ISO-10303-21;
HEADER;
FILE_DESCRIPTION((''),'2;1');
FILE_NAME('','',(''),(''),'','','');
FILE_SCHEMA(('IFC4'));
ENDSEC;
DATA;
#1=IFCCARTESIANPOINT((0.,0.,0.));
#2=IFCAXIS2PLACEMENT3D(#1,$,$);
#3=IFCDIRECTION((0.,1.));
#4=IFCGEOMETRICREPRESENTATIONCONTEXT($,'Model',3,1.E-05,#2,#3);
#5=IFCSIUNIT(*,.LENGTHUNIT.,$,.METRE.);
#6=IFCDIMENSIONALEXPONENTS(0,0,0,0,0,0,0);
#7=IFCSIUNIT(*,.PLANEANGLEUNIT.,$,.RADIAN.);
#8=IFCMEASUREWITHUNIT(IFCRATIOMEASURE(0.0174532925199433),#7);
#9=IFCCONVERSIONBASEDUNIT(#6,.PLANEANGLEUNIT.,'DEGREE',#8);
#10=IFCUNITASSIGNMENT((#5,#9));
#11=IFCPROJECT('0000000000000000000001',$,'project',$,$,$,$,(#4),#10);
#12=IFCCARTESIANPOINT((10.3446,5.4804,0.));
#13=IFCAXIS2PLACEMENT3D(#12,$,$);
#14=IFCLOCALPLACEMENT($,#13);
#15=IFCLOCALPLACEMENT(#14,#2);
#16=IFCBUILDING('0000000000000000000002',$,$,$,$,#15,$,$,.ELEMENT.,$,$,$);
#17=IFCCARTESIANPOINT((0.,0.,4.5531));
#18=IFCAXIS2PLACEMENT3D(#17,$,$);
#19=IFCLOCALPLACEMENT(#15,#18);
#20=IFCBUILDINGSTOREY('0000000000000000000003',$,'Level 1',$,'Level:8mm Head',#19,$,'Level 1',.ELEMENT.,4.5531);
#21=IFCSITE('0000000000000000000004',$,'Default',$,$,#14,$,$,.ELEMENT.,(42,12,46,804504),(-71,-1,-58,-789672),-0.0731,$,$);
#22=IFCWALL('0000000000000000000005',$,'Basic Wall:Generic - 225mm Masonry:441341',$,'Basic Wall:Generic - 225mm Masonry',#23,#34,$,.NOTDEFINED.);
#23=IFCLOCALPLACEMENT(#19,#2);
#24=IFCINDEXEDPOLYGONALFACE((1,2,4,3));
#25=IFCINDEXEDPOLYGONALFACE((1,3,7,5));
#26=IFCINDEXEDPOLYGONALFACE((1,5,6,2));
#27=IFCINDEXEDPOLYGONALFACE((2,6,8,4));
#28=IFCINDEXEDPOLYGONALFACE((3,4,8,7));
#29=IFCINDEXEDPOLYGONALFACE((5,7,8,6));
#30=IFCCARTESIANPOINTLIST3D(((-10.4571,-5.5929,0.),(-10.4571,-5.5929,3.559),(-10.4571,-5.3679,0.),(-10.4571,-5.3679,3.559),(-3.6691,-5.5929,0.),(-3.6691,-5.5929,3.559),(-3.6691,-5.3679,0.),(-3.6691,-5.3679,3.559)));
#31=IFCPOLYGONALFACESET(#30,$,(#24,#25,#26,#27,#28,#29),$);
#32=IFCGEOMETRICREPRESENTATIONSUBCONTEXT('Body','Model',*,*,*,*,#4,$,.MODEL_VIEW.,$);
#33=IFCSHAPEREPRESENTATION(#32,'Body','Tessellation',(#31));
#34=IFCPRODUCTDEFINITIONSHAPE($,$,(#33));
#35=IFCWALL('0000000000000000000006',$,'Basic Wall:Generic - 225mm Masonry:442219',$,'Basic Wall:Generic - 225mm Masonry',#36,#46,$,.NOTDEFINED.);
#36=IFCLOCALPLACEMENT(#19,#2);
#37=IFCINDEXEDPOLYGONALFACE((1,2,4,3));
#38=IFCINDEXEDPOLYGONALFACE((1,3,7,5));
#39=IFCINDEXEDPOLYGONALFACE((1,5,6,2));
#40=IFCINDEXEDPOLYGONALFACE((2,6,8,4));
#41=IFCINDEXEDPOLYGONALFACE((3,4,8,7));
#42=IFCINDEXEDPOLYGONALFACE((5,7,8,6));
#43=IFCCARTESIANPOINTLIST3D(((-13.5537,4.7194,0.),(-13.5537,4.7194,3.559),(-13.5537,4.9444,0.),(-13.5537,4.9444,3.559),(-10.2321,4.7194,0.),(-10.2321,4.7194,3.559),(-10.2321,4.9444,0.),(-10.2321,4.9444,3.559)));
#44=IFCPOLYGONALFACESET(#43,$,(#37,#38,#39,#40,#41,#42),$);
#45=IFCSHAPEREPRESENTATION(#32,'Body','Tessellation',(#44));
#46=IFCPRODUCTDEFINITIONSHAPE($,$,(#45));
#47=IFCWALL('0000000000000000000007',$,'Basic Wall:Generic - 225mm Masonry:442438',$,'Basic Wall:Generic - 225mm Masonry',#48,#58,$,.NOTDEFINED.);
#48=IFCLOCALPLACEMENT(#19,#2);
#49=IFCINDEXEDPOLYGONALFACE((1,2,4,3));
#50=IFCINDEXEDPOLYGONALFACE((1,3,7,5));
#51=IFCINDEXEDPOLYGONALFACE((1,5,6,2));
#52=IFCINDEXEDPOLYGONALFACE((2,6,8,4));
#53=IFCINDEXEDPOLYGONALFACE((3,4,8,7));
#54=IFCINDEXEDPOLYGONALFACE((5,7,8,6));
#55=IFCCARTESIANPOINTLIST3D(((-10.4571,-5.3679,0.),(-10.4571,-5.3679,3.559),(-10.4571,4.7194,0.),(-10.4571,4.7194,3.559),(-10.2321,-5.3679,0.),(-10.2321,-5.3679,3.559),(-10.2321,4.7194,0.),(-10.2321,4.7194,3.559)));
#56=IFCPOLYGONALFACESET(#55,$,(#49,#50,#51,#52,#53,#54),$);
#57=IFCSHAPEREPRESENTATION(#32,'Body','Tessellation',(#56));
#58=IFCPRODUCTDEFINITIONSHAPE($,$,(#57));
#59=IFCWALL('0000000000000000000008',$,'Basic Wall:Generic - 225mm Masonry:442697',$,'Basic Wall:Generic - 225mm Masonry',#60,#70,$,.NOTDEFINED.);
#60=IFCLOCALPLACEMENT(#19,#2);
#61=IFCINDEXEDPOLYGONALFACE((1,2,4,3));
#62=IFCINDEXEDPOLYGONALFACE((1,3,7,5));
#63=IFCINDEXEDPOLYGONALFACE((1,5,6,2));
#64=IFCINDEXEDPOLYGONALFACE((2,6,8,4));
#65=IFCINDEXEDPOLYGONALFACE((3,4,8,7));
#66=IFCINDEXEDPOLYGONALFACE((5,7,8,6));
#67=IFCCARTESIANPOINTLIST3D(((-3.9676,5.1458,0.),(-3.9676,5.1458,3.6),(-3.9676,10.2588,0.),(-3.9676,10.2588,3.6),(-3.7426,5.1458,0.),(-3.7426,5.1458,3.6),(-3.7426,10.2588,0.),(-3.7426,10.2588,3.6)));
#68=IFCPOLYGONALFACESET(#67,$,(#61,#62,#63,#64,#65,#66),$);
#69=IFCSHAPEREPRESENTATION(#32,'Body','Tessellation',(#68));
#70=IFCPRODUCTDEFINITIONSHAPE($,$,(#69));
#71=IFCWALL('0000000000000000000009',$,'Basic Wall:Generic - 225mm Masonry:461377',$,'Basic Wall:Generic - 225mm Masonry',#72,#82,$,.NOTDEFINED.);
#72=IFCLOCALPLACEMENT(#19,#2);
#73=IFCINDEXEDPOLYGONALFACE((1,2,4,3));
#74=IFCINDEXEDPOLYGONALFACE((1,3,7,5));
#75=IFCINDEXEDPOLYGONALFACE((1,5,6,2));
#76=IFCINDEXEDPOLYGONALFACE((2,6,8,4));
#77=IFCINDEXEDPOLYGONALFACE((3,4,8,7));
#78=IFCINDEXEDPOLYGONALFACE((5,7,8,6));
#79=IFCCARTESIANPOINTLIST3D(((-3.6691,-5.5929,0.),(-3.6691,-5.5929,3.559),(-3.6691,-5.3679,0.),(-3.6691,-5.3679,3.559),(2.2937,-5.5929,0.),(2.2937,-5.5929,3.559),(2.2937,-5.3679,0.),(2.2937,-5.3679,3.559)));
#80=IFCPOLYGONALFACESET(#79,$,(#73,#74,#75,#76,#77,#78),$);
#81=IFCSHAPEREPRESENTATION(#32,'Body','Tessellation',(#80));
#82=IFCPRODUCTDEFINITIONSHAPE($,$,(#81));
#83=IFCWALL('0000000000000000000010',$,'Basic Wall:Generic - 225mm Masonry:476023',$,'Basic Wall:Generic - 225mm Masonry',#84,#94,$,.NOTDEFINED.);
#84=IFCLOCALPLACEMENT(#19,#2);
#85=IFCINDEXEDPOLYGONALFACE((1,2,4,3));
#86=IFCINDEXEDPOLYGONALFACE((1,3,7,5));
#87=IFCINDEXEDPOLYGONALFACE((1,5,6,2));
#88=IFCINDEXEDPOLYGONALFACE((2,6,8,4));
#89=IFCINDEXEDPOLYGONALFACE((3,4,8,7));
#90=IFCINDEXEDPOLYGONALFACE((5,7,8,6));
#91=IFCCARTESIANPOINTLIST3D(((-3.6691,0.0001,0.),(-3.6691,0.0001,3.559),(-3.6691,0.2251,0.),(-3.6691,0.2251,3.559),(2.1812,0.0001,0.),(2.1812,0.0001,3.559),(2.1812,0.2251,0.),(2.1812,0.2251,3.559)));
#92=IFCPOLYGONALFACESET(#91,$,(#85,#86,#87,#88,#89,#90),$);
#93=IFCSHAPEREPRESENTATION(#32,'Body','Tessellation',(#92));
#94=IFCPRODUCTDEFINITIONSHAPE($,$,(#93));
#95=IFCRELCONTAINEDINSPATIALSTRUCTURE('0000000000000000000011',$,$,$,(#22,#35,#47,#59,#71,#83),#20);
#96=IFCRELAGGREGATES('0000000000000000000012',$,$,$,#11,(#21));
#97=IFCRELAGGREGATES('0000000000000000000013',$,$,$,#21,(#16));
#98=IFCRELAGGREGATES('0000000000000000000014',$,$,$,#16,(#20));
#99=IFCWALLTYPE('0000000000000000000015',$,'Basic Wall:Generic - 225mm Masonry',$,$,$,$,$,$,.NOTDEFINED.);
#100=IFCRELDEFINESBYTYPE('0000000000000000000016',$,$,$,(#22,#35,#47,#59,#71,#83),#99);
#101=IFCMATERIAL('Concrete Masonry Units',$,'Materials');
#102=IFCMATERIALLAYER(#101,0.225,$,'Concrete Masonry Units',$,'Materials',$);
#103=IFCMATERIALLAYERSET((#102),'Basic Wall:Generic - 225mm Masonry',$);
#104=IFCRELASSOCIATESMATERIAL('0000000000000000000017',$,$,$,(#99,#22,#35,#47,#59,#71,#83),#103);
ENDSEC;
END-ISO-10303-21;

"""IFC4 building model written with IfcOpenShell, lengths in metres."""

from ifc_helpers import new_model, entity, si_unit, converted_unit, direction, frame, frame_2d, origin, place, context, subcontext, project, spatial, polyline, rectangle, extrude, clip, bounded_halfspace, material, layer, layer_set, layer_usage, type_object, element, save


model = new_model("IFC4")

# Units and contexts
model_context = context("Model", 3, precision=1e-05, world=origin(), true_north=direction((0.0, 1.0)))
body_context = subcontext(model_context, "Body", "Model", "MODEL_VIEW")
ifc_project = project(units=[si_unit("LENGTHUNIT", "METRE"), converted_unit("PLANEANGLEUNIT", "DEGREE", entity("IfcRatioMeasure", 0.0174532925199433), si_unit("PLANEANGLEUNIT", "RADIAN"), dimensions=[0, 0, 0, 0, 0, 0, 0])], contexts=[model_context])

# Site, building, storey
site_placement = place(None, frame((10.3446, 5.4804, 0.0)))
site = spatial("IfcSite", under=ifc_project, at=site_placement, Name="Default", CompositionType="ELEMENT", RefLatitude=(42, 12, 46, 804504), RefLongitude=(-71, -1, -58, -789672), RefElevation=-0.0731)
building_placement = place(site_placement, origin())
building = spatial("IfcBuilding", under=site, at=building_placement, CompositionType="ELEMENT")
storey_placement = place(building_placement, frame((0.0, 0.0, 4.5531)))
storey = spatial("IfcBuildingStorey", under=building, at=storey_placement, Name="Level 1", ObjectType="Level:8mm Head", LongName="Level 1", CompositionType="ELEMENT", Elevation=4.5531)

# Walls
ifc_material_1 = material(Name="Concrete Masonry Units", Category="Materials")
ifc_layer = layer(ifc_material_1, 0.225, Name="Concrete Masonry Units", Category="Materials")
ifc_layer_set = layer_set([ifc_layer], Name="Basic Wall:Generic - 225mm Masonry")
ifc_layer_usage_1 = layer_usage(ifc_layer_set, "AXIS2", "NEGATIVE", 0.1125)
wall_type = type_object("IfcWallType", Name="Basic Wall:Generic - 225mm Masonry", PredefinedType="NOTDEFINED", material=ifc_layer_set)
wall_1_placement = place(storey_placement, frame((-10.4571, -5.4804, 0.0)))
element("IfcWall", 1, at=wall_1_placement, inside=storey, type_object=wall_type, material=ifc_layer_usage_1, Name="Basic Wall:Generic - 225mm Masonry:441341", ObjectType="Basic Wall:Generic - 225mm Masonry", PredefinedType="NOTDEFINED", context=body_context, shape_type="Clipping", body=[
    clip(extrude(rectangle(XDim=6.7881, YDim=0.225, at=frame_2d((3.394, 0.0), x_axis=(-1.0, 0.0))), origin(), (0.0, 0.0, 1.0), 3.559), bounded_halfspace(frame((6.7881, 0.0, 3.559), z_axis=(0.0, 0.0, -1.0), x_axis=(-1.0, 0.0, 0.0)), True, frame((6.7881, 0.0, 3.559)), polyline([(0.0, 0.0), (0.0, 0.1125), (-0.1125, 0.1125), (-6.5631, 0.1125), (-6.6756, 0.1125), (-6.6756, 0.0), (0.0, 0.0)]))),
])
ifc_layer_usage_2 = layer_usage(ifc_layer_set, "AXIS2", "NEGATIVE", 0.1125)
wall_2_placement = place(storey_placement, frame((-13.5537, 4.8319, 0.0)))
element("IfcWall", 2, at=wall_2_placement, inside=storey, type_object=wall_type, material=ifc_layer_usage_2, Name="Basic Wall:Generic - 225mm Masonry:442219", ObjectType="Basic Wall:Generic - 225mm Masonry", PredefinedType="NOTDEFINED", context=body_context, shape_type="Clipping", body=[
    clip(extrude(rectangle(XDim=3.3216, YDim=0.225, at=frame_2d((1.6608, 0.0), x_axis=(-1.0, 0.0))), origin(), (0.0, 0.0, 1.0), 3.559), bounded_halfspace(frame((3.2091, -0.1125, 3.559), z_axis=(0.0, 0.0, -1.0), x_axis=(-1.0, 0.0, 0.0)), True, frame((3.2091, -0.1125, 3.559)), polyline([(0.0, 0.0), (0.1125, 0.0), (0.1125, 0.2014), (0.1125, 0.225), (0.0, 0.225), (0.0, 0.0)]))),
])
ifc_layer_usage_3 = layer_usage(ifc_layer_set, "AXIS2", "NEGATIVE", 0.1125)
wall_3_placement = place(storey_placement, frame((-10.3446, 4.7194, 0.0), z_axis=(0.0, 0.0, 1.0), x_axis=(0.0, -1.0, 0.0)))
element("IfcWall", 3, at=wall_3_placement, inside=storey, type_object=wall_type, material=ifc_layer_usage_3, Name="Basic Wall:Generic - 225mm Masonry:442438", ObjectType="Basic Wall:Generic - 225mm Masonry", PredefinedType="NOTDEFINED", context=body_context, shape_type="Clipping", body=[
    clip(extrude(rectangle(XDim=10.0873, YDim=0.225, at=frame_2d((5.0437, 0.0), x_axis=(-1.0, 0.0))), origin(), (0.0, 0.0, 1.0), 3.559), bounded_halfspace(frame((10.0873, 0.0, 3.559), z_axis=(0.0, 0.0, -1.0), x_axis=(0.0, -1.0, 0.0)), True, frame((10.0873, 0.0, 3.559)), polyline([(0.0, 0.0), (0.0, 0.1125), (-10.0873, 0.1125), (-10.0873, 0.0), (0.0, 0.0)]))),
])
ifc_layer_usage_4 = layer_usage(ifc_layer_set, "AXIS2", "NEGATIVE", 0.1125)
wall_4_placement = place(storey_placement, frame((-3.8551, 10.2588, 0.0), z_axis=(0.0, 0.0, 1.0), x_axis=(0.0, -1.0, 0.0)))
element("IfcWall", 4, at=wall_4_placement, inside=storey, type_object=wall_type, material=ifc_layer_usage_4, Name="Basic Wall:Generic - 225mm Masonry:442697", ObjectType="Basic Wall:Generic - 225mm Masonry", PredefinedType="NOTDEFINED", context=body_context, shape_type="SweptSolid", body=[
    extrude(rectangle(XDim=5.113, YDim=0.225, at=frame_2d((2.5565, 0.0), x_axis=(-1.0, 0.0))), origin(), (0.0, 0.0, 1.0), 3.6),
])
ifc_layer_usage_5 = layer_usage(ifc_layer_set, "AXIS2", "NEGATIVE", 0.1125)
wall_5_placement = place(storey_placement, frame((-3.6691, -5.4804, 0.0)))
element("IfcWall", 5, at=wall_5_placement, inside=storey, type_object=wall_type, material=ifc_layer_usage_5, Name="Basic Wall:Generic - 225mm Masonry:461377", ObjectType="Basic Wall:Generic - 225mm Masonry", PredefinedType="NOTDEFINED", context=body_context, shape_type="Clipping", body=[
    clip(extrude(rectangle(XDim=5.9627, YDim=0.225, at=frame_2d((2.9814, 0.0), x_axis=(-1.0, 0.0))), origin(), (0.0, 0.0, 1.0), 3.559), bounded_halfspace(frame((5.9627, 0.0, 3.559), z_axis=(0.0, 0.0, -1.0), x_axis=(-1.0, 0.0, 0.0)), True, frame((5.9627, 0.0, 3.559)), polyline([(0.0, 0.0), (0.0, 0.1125), (-5.8502, 0.1125), (-5.9627, 0.1125), (-5.9627, 0.0), (0.0, 0.0)]))),
])
ifc_layer_usage_6 = layer_usage(ifc_layer_set, "AXIS2", "NEGATIVE", 0.1125)
wall_6_placement = place(storey_placement, frame((-3.6691, 0.1126, 0.0)))
element("IfcWall", 6, at=wall_6_placement, inside=storey, type_object=wall_type, material=ifc_layer_usage_6, Name="Basic Wall:Generic - 225mm Masonry:476023", ObjectType="Basic Wall:Generic - 225mm Masonry", PredefinedType="NOTDEFINED", context=body_context, shape_type="Clipping", body=[
    clip(extrude(rectangle(XDim=5.8502, YDim=0.225, at=frame_2d((2.9251, 0.0), x_axis=(-1.0, 0.0))), origin(), (0.0, 0.0, 1.0), 3.559), bounded_halfspace(frame((5.8502, 0.0, 3.559), z_axis=(0.0, 0.0, -1.0), x_axis=(-1.0, 0.0, 0.0)), True, frame((5.8502, 0.0, 3.559)), polyline([(0.0, 0.0), (0.0, 0.1125), (-5.8502, 0.1125), (-5.8502, 0.0), (-5.8502, -0.1125), (0.0, -0.1125), (0.0, -0.0554), (0.0, 0.0)]))),
])

save(model, "model.ifc")
